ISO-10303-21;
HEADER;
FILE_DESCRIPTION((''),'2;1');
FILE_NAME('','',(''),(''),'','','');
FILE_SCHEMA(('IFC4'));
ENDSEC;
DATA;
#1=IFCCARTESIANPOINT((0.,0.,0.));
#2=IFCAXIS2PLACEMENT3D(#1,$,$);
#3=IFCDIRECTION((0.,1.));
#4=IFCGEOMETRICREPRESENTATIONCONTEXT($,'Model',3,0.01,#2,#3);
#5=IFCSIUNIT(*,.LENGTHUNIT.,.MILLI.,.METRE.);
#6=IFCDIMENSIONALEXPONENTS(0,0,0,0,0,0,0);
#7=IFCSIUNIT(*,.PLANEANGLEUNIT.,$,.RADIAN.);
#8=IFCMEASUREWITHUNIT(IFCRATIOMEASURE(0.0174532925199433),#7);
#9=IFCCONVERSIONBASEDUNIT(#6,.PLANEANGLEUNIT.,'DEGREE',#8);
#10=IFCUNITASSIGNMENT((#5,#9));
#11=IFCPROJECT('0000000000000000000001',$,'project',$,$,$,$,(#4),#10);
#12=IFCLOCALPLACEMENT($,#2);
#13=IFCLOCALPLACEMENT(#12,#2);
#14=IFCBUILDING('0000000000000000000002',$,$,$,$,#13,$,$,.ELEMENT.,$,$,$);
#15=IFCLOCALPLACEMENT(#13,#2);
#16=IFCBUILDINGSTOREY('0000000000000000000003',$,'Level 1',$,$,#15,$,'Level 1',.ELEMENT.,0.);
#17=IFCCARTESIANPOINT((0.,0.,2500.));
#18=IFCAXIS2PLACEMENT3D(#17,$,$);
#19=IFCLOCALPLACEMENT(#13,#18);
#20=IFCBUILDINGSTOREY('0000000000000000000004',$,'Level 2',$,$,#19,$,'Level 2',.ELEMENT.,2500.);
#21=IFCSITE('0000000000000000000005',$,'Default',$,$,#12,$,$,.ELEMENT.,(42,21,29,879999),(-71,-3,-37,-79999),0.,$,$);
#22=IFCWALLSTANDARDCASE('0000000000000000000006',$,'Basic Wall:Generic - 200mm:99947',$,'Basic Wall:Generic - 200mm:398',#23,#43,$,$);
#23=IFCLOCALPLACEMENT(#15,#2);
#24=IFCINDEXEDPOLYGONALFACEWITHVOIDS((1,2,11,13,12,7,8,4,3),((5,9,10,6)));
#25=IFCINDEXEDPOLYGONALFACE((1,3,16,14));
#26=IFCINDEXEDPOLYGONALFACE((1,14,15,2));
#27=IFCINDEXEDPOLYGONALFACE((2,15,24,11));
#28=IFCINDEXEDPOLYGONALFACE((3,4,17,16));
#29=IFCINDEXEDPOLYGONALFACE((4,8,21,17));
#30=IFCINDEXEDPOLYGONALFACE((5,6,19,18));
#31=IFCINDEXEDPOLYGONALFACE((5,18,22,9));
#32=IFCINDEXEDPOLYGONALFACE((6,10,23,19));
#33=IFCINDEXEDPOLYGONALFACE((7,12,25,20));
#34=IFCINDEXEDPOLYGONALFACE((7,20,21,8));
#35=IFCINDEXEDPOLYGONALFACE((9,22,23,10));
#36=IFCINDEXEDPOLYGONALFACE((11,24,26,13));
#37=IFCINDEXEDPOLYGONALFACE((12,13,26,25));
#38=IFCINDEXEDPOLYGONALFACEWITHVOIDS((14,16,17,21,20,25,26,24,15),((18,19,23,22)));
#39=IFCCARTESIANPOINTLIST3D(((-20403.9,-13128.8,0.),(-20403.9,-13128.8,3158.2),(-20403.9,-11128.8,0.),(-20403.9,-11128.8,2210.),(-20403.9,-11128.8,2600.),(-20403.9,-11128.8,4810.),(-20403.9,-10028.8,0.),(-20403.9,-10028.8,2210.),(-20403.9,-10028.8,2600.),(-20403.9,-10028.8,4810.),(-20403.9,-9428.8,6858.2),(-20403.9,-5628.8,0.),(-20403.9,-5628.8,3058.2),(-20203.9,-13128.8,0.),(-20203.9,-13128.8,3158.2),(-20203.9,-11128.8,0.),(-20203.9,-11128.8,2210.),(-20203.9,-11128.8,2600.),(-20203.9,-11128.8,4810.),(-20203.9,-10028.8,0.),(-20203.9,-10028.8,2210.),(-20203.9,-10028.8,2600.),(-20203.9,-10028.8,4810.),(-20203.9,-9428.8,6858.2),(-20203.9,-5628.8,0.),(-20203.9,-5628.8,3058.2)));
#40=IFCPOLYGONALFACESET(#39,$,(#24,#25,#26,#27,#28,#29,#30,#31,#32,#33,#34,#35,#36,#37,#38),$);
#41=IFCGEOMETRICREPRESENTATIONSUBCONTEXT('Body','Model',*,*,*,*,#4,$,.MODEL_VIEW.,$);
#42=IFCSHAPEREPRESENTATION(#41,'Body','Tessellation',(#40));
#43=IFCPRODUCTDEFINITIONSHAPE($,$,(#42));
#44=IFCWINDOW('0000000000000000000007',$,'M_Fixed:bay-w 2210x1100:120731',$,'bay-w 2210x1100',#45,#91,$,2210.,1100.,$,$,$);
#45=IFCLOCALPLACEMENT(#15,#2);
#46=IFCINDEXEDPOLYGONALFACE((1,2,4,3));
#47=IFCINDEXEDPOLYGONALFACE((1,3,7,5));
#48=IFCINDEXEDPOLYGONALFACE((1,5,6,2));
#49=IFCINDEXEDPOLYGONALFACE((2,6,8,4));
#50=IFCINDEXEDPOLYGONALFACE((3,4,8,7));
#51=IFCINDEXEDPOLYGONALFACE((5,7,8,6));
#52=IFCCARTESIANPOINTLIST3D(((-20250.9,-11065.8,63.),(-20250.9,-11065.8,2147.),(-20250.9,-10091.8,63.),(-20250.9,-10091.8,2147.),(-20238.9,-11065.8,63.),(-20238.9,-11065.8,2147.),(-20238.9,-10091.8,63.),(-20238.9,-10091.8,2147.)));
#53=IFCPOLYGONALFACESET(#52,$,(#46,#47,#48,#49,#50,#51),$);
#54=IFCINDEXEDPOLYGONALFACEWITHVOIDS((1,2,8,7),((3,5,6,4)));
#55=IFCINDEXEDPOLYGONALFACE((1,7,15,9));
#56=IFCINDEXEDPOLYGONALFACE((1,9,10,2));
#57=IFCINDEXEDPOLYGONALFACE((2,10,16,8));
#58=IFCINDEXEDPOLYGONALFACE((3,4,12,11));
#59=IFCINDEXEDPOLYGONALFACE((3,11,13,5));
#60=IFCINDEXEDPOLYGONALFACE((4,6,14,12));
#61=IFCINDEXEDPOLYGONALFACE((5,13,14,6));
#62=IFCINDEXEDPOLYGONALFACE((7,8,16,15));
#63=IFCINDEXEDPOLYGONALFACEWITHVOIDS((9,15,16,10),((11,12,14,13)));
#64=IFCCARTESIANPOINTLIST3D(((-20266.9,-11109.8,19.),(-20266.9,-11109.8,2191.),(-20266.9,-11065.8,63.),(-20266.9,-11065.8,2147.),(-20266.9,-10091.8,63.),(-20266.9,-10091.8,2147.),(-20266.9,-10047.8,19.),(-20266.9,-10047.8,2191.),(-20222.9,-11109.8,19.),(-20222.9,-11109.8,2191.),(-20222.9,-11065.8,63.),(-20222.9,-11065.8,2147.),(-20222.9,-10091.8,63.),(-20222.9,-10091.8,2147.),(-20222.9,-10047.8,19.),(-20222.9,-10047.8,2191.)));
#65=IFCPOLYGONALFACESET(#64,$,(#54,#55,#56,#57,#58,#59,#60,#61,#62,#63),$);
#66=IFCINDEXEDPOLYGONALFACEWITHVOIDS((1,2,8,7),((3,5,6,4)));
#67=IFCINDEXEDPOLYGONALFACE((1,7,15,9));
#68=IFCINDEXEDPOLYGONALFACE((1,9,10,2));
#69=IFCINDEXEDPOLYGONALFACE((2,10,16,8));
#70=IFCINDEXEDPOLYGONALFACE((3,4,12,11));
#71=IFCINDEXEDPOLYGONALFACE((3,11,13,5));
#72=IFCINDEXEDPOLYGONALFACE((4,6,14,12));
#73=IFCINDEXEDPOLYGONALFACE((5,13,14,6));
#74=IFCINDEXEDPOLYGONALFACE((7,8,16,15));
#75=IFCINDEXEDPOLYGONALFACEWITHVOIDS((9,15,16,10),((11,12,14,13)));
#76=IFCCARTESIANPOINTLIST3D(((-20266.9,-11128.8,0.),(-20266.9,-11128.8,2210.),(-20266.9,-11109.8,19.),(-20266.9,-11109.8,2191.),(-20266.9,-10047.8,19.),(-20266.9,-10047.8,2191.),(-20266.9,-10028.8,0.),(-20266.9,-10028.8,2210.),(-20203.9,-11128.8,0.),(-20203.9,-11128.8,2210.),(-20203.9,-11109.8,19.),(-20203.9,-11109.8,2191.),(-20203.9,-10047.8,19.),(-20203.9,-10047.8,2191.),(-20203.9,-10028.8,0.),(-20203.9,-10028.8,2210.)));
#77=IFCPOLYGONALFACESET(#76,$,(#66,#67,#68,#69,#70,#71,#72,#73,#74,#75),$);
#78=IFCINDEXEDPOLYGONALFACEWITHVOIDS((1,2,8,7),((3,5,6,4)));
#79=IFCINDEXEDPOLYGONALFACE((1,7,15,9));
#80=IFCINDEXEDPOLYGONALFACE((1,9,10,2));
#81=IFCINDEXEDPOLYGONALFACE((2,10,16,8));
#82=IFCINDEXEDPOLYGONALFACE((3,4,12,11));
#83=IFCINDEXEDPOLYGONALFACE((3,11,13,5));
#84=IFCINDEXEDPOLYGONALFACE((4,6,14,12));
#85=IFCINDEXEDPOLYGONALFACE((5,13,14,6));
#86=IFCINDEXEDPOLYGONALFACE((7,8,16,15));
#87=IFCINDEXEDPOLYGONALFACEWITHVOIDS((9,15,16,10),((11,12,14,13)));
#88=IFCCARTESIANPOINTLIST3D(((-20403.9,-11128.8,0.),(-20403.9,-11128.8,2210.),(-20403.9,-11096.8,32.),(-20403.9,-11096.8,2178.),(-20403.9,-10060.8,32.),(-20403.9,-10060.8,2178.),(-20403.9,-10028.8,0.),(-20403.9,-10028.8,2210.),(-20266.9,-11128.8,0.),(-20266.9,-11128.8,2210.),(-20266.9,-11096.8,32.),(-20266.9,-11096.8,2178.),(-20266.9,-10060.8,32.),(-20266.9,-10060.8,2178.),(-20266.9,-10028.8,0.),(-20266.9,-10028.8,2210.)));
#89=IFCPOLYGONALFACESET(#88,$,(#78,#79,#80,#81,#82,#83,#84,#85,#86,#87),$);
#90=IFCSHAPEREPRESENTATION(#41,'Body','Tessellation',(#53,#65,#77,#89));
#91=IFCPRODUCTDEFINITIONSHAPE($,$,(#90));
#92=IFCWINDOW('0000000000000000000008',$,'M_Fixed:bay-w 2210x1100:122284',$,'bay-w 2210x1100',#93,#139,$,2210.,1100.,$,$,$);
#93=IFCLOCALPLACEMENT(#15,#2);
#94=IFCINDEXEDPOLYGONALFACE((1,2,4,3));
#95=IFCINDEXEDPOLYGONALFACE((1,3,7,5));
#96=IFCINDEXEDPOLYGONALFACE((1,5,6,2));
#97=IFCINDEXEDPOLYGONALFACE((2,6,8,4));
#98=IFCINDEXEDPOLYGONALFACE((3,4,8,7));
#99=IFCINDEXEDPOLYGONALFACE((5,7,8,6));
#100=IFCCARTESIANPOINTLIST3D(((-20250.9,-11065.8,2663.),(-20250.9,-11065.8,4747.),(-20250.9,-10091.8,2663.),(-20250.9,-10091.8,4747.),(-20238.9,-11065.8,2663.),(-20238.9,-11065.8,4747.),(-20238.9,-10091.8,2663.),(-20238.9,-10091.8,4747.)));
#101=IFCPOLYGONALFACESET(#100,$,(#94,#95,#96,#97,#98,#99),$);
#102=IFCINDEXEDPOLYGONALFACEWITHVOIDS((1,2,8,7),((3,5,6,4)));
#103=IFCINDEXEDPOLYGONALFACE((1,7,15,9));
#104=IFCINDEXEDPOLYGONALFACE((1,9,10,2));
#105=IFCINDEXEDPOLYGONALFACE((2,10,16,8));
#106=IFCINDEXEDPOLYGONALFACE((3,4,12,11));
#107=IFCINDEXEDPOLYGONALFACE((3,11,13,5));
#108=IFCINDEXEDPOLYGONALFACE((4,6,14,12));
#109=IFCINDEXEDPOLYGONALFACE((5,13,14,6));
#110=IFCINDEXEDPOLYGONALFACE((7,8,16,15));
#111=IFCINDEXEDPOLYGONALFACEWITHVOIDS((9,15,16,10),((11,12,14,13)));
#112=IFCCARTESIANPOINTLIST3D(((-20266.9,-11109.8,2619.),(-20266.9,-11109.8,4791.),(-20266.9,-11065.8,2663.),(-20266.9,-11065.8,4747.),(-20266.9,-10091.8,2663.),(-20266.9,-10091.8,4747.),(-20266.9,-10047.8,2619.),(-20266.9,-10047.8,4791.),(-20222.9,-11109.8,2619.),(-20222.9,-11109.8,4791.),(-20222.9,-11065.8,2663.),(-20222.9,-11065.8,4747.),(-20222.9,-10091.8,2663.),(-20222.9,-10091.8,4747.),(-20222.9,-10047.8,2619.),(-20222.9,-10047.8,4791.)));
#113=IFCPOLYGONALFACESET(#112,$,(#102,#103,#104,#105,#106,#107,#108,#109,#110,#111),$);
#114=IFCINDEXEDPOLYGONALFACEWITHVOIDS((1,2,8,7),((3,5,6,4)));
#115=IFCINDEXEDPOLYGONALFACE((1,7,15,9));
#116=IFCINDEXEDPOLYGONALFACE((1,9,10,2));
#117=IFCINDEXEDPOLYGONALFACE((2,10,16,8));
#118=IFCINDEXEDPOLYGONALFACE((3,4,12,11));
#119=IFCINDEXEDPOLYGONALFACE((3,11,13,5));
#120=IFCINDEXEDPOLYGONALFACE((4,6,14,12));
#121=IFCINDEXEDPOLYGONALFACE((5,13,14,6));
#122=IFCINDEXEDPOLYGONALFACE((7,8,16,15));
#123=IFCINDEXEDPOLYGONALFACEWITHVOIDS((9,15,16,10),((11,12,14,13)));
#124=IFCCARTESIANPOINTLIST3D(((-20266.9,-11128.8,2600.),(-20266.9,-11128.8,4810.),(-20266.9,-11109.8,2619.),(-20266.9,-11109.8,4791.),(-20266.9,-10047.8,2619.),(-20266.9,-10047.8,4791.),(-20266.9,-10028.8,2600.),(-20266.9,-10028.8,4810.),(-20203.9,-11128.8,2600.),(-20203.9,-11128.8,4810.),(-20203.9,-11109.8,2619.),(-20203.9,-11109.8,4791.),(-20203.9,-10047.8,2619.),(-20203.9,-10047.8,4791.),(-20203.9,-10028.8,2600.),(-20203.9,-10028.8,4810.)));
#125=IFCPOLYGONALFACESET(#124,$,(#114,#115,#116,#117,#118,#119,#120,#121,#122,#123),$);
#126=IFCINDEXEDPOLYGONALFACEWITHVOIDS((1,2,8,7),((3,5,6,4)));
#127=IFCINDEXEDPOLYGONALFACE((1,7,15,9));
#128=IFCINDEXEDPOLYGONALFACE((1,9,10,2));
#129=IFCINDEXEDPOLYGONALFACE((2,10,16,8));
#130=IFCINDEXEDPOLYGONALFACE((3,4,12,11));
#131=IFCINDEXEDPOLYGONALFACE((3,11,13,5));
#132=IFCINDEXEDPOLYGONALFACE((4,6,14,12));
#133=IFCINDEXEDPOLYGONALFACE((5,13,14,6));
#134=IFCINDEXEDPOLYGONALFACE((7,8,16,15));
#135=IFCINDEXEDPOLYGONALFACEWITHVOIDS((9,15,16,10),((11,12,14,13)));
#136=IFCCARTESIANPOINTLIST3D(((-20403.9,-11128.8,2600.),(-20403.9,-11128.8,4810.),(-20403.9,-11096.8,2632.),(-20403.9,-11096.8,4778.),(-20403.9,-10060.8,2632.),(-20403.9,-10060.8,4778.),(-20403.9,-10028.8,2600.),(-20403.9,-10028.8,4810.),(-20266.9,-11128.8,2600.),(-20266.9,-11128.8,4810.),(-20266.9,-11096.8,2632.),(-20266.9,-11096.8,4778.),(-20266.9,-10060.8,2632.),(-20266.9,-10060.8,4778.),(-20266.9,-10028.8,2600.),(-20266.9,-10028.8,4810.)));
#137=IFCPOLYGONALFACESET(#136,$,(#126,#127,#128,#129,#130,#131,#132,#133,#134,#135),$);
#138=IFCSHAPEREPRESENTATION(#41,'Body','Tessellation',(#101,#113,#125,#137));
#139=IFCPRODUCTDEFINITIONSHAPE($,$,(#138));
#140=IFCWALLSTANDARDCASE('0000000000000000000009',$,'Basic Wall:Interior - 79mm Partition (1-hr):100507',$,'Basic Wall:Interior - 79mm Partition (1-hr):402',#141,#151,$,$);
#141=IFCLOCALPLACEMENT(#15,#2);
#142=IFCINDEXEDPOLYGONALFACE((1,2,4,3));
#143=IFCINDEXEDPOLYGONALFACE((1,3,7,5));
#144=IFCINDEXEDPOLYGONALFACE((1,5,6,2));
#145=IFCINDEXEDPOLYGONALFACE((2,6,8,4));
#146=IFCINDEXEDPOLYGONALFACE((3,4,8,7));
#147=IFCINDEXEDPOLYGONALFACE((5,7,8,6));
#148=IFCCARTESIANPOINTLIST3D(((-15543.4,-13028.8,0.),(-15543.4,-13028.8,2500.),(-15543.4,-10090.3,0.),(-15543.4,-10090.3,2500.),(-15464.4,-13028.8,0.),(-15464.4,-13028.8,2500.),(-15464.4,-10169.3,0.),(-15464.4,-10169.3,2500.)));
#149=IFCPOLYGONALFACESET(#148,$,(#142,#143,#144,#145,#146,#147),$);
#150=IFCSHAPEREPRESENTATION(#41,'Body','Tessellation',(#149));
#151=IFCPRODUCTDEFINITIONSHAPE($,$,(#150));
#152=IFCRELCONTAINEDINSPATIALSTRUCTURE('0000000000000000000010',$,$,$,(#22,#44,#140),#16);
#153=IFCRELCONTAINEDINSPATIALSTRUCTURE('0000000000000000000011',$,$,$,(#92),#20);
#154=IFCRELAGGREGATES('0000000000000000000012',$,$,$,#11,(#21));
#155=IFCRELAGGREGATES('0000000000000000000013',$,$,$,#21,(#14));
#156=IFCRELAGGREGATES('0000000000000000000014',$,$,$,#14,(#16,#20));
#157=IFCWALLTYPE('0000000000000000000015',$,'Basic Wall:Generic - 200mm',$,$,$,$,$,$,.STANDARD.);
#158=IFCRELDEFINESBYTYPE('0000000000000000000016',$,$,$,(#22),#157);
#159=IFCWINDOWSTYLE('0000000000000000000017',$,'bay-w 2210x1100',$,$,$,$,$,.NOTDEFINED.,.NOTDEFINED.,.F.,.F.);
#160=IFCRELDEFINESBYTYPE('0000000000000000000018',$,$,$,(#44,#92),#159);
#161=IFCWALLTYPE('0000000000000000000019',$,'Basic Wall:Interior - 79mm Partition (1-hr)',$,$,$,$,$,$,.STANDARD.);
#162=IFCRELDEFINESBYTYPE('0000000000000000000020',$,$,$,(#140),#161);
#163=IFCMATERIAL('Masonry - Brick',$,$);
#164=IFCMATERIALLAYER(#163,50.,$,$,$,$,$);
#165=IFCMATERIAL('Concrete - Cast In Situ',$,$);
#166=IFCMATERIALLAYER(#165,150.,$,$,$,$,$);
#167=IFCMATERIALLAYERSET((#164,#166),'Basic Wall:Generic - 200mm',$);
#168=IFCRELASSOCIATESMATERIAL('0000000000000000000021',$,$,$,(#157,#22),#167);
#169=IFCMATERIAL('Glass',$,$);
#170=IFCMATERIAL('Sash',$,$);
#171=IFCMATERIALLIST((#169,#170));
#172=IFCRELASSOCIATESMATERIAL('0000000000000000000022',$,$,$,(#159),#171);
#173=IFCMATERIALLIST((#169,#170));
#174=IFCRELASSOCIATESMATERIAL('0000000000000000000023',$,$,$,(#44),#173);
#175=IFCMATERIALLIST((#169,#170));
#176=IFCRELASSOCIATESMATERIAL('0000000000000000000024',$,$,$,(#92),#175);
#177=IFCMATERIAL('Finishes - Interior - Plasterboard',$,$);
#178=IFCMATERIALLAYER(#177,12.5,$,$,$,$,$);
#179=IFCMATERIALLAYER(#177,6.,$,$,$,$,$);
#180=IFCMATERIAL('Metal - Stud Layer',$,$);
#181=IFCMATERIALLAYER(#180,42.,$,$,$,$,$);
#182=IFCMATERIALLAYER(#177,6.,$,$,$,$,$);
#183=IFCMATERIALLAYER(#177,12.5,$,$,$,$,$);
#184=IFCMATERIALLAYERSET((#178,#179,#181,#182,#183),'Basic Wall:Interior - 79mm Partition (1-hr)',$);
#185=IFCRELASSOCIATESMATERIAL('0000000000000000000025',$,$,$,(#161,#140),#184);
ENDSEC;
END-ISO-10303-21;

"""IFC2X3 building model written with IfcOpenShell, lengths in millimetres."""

from ifc_helpers import new_model, entity, si_unit, converted_unit, direction, frame, frame_2d, origin, place, context, subcontext, project, spatial, polyline, rectangle, outline, extrude, clip, bounded_halfspace, source, transform, mapped, material, material_list, layer, layer_set, layer_usage, type_object, type_shapes, element, fill, save


model = new_model("IFC2X3")

# Units and contexts
model_context = context("Model", 3, precision=0.01, world=origin(), true_north=direction((0.0, 1.0)))
body_context = subcontext(model_context, "Body", "Model", "MODEL_VIEW")
ifc_project = project(units=[si_unit("LENGTHUNIT", "METRE", prefix="MILLI"), converted_unit("PLANEANGLEUNIT", "DEGREE", entity("IfcRatioMeasure", 0.0174532925199433), si_unit("PLANEANGLEUNIT", "RADIAN"), dimensions=[0, 0, 0, 0, 0, 0, 0])], contexts=[model_context])

# Site, building, storey
site_placement = place(None, origin())
site = spatial("IfcSite", under=ifc_project, at=site_placement, Name="Default", CompositionType="ELEMENT", RefLatitude=(42, 21, 29, 879999), RefLongitude=(-71, -3, -37, -79999), RefElevation=0.0)
building_placement = place(site_placement, origin())
building = spatial("IfcBuilding", under=site, at=building_placement, CompositionType="ELEMENT")
storey_1_placement = place(building_placement, origin())
storey_1 = spatial("IfcBuildingStorey", under=building, at=storey_1_placement, Name="Level 1", LongName="Level 1", CompositionType="ELEMENT", Elevation=0.0)

# Wall, openings, window
ifc_material_1 = material(Name="Masonry - Brick")
ifc_layer_1 = layer(ifc_material_1, 50.0)
ifc_material_2 = material(Name="Concrete - Cast In Situ")
ifc_layer_2 = layer(ifc_material_2, 150.0)
ifc_layer_set_1 = layer_set([ifc_layer_1, ifc_layer_2], Name="Basic Wall:Generic - 200mm")
ifc_layer_usage_1 = layer_usage(ifc_layer_set_1, "AXIS2", "NEGATIVE", 100.0)
wall_type_1 = type_object("IfcWallType", Name="Basic Wall:Generic - 200mm", PredefinedType="STANDARD", material=ifc_layer_set_1)
wall_1_placement = place(storey_1_placement, frame((-20303.9, -13128.8, 0.0), z_axis=(0.0, 0.0, 1.0), x_axis=(0.0, 1.0, 0.0)))
wall_1 = element("IfcWallStandardCase", 1, at=wall_1_placement, inside=storey_1, type_object=wall_type_1, material=ifc_layer_usage_1, Name="Basic Wall:Generic - 200mm:99947", ObjectType="Basic Wall:Generic - 200mm:398", context=body_context, shape_type="Clipping", body=[
    clip(clip(extrude(rectangle(XDim=7500.0, YDim=200.0, at=frame_2d((3750.0, 0.0), x_axis=(-1.0, 0.0))), origin(), (0.0, 0.0, 1.0), 6858.2), bounded_halfspace(frame((0.0, 100.0, 3158.2), z_axis=(0.707107, 0.0, -0.707107), x_axis=(0.0, 1.0, 0.0)), True, frame((0.0, 100.0, 3158.2)), polyline([(0.0, 0.0), (0.0, -200.0), (493.0, -200.0), (707.0, -200.0), (3607.0, -200.0), (3700.0, -200.0), (3700.0, 0.0), (0.0, 0.0)]))), bounded_halfspace(frame((7500.0, -100.0, 3058.2), z_axis=(-0.707107, 0.0, -0.707107), x_axis=(0.0, 1.0, 0.0)), True, frame((7500.0, -100.0, 3058.2)), polyline([(0.0, 0.0), (0.0, 200.0), (-3800.0, 200.0), (-3800.0, 0.0), (-3393.0, 0.0), (-807.0, 0.0), (-593.0, 0.0), (0.0, 0.0)]))),
])
opening_1_placement = place(wall_1_placement, frame((3100.0, 100.0, 0.0)))
opening_1 = element("IfcOpeningElement", 2, at=opening_1_placement, cuts=wall_1, ObjectType="Opening", context=body_context, shape_type="SweptSolid", body=[
    extrude(rectangle(XDim=2210.0, YDim=1100.0, at=frame_2d((1105.0, 550.0), x_axis=(1.0, 0.0))), frame((0.0, 0.0, 0.0), z_axis=(0.0, -1.0, 0.0), x_axis=(0.0, 0.0, 1.0)), (0.0, 0.0, 1.0), 200.0),
])
opening_2_placement = place(wall_1_placement, frame((3100.0, 100.0, 2600.0)))
opening_2 = element("IfcOpeningElement", 3, at=opening_2_placement, cuts=wall_1, ObjectType="Opening", context=body_context, shape_type="SweptSolid", body=[
    extrude(rectangle(XDim=2210.0, YDim=1100.0, at=frame_2d((1105.0, 550.0), x_axis=(1.0, 0.0))), frame((0.0, 0.0, 0.0), z_axis=(0.0, -1.0, 0.0), x_axis=(0.0, 0.0, 1.0)), (0.0, 0.0, 1.0), 200.0),
])
ifc_material_3 = material(Name="Glass")
ifc_material_4 = material(Name="Sash")
ifc_material_list_1 = material_list([ifc_material_3, ifc_material_4])
ifc_material_list_2 = material_list([ifc_material_3, ifc_material_4])
window_style_1 = type_object("IfcWindowStyle", Name="bay-w 2210x1100", ConstructionType="NOTDEFINED", OperationType="NOTDEFINED", ParameterTakesPrecedence=False, Sizeable=False, material=ifc_material_list_2)
shared_shape_1 = source(origin(), body_context, "Body", "SweptSolid", [
    extrude(rectangle(XDim=12.0, YDim=974.0, at=frame_2d((0.0, 0.0), x_axis=(1.0, 0.0))), frame((550.0, 159.0, 63.0), z_axis=(0.0, 0.0, 1.0), x_axis=(0.0, -1.0, 0.0)), (0.0, 0.0, 1.0), 2084.0),
    extrude(outline(polyline([(-531.0, -1086.0), (531.0, -1086.0), (531.0, 1086.0), (-531.0, 1086.0), (-531.0, -1086.0)]), holes=[polyline([(-487.0, -1042.0), (-487.0, 1042.0), (487.0, 1042.0), (487.0, -1042.0), (-487.0, -1042.0)])]), frame((550.0, 137.0, 1105.0), z_axis=(0.0, 1.0, 0.0), x_axis=(1.0, 0.0, 0.0)), (0.0, 0.0, 1.0), 44.0),
    extrude(outline(polyline([(-550.0, -1105.0), (550.0, -1105.0), (550.0, 1105.0), (-550.0, 1105.0), (-550.0, -1105.0)]), holes=[polyline([(-531.0, -1086.0), (-531.0, 1086.0), (531.0, 1086.0), (531.0, -1086.0), (-531.0, -1086.0)])]), frame((550.0, 137.0, 1105.0), z_axis=(0.0, 1.0, 0.0), x_axis=(1.0, 0.0, 0.0)), (0.0, 0.0, 1.0), 63.0),
    extrude(outline(polyline([(-550.0, -1105.0), (550.0, -1105.0), (550.0, 1105.0), (-550.0, 1105.0), (-550.0, -1105.0)]), holes=[polyline([(-518.0, -1073.0), (-518.0, 1073.0), (518.0, 1073.0), (518.0, -1073.0), (-518.0, -1073.0)])]), frame((550.0, 0.0, 1105.0), z_axis=(0.0, 1.0, 0.0), x_axis=(1.0, 0.0, 0.0)), (0.0, 0.0, 1.0), 137.0),
])
type_shapes(window_style_1, [shared_shape_1])
window_1_placement = place(opening_1_placement, frame((0.0, 0.0, 0.0), z_axis=(0.0, 0.0, 1.0), x_axis=(-1.0, 0.0, 0.0)))
window_1 = element("IfcWindow", 4, at=window_1_placement, inside=storey_1, type_object=window_style_1, material=ifc_material_list_1, Name="M_Fixed:bay-w 2210x1100:120731", ObjectType="bay-w 2210x1100", OverallHeight=2210.0, OverallWidth=1100.0, context=body_context, shape_type="MappedRepresentation", body=[
    mapped(shared_shape_1, transform((0.0, 0.0, 0.0), scale=1.0)),
])
fill(opening_1, window_1)

# Shared definitions
storey_2_placement = place(building_placement, frame((0.0, 0.0, 2500.0)))
storey_2 = spatial("IfcBuildingStorey", under=building, at=storey_2_placement, Name="Level 2", LongName="Level 2", CompositionType="ELEMENT", Elevation=2500.0)

# Window
ifc_material_list_3 = material_list([ifc_material_3, ifc_material_4])
window_2_placement = place(opening_2_placement, frame((0.0, 0.0, 0.0), z_axis=(0.0, 0.0, 1.0), x_axis=(-1.0, 0.0, 0.0)))
window_2 = element("IfcWindow", 5, at=window_2_placement, inside=storey_2, type_object=window_style_1, material=ifc_material_list_3, Name="M_Fixed:bay-w 2210x1100:122284", ObjectType="bay-w 2210x1100", OverallHeight=2210.0, OverallWidth=1100.0, context=body_context, shape_type="MappedRepresentation", body=[
    mapped(shared_shape_1, transform((0.0, 0.0, 0.0), scale=1.0)),
])
fill(opening_2, window_2)

# Wall
ifc_material_5 = material(Name="Finishes - Interior - Plasterboard")
ifc_layer_3 = layer(ifc_material_5, 12.5)
ifc_layer_4 = layer(ifc_material_5, 6.0)
ifc_material_6 = material(Name="Metal - Stud Layer")
ifc_layer_5 = layer(ifc_material_6, 42.0)
ifc_layer_6 = layer(ifc_material_5, 6.0)
ifc_layer_7 = layer(ifc_material_5, 12.5)
ifc_layer_set_2 = layer_set([ifc_layer_3, ifc_layer_4, ifc_layer_5, ifc_layer_6, ifc_layer_7], Name="Basic Wall:Interior - 79mm Partition (1-hr)")
ifc_layer_usage_2 = layer_usage(ifc_layer_set_2, "AXIS2", "NEGATIVE", 39.5)
wall_type_2 = type_object("IfcWallType", Name="Basic Wall:Interior - 79mm Partition (1-hr)", PredefinedType="STANDARD", material=ifc_layer_set_2)
wall_2_placement = place(storey_1_placement, frame((-15503.9, -13028.8, 0.0), z_axis=(0.0, 0.0, 1.0), x_axis=(0.0, 1.0, 0.0)))
element("IfcWallStandardCase", 6, at=wall_2_placement, inside=storey_1, type_object=wall_type_2, material=ifc_layer_usage_2, Name="Basic Wall:Interior - 79mm Partition (1-hr):100507", ObjectType="Basic Wall:Interior - 79mm Partition (1-hr):402", context=body_context, shape_type="SweptSolid", body=[
    extrude(outline(polyline([(2859.5, -39.5), (2938.5, 39.5), (0.0, 39.5), (0.0, -39.5), (2859.5, -39.5)])), origin(), (0.0, 0.0, 1.0), 2500.0),
])

save(model, "model.ifc")
